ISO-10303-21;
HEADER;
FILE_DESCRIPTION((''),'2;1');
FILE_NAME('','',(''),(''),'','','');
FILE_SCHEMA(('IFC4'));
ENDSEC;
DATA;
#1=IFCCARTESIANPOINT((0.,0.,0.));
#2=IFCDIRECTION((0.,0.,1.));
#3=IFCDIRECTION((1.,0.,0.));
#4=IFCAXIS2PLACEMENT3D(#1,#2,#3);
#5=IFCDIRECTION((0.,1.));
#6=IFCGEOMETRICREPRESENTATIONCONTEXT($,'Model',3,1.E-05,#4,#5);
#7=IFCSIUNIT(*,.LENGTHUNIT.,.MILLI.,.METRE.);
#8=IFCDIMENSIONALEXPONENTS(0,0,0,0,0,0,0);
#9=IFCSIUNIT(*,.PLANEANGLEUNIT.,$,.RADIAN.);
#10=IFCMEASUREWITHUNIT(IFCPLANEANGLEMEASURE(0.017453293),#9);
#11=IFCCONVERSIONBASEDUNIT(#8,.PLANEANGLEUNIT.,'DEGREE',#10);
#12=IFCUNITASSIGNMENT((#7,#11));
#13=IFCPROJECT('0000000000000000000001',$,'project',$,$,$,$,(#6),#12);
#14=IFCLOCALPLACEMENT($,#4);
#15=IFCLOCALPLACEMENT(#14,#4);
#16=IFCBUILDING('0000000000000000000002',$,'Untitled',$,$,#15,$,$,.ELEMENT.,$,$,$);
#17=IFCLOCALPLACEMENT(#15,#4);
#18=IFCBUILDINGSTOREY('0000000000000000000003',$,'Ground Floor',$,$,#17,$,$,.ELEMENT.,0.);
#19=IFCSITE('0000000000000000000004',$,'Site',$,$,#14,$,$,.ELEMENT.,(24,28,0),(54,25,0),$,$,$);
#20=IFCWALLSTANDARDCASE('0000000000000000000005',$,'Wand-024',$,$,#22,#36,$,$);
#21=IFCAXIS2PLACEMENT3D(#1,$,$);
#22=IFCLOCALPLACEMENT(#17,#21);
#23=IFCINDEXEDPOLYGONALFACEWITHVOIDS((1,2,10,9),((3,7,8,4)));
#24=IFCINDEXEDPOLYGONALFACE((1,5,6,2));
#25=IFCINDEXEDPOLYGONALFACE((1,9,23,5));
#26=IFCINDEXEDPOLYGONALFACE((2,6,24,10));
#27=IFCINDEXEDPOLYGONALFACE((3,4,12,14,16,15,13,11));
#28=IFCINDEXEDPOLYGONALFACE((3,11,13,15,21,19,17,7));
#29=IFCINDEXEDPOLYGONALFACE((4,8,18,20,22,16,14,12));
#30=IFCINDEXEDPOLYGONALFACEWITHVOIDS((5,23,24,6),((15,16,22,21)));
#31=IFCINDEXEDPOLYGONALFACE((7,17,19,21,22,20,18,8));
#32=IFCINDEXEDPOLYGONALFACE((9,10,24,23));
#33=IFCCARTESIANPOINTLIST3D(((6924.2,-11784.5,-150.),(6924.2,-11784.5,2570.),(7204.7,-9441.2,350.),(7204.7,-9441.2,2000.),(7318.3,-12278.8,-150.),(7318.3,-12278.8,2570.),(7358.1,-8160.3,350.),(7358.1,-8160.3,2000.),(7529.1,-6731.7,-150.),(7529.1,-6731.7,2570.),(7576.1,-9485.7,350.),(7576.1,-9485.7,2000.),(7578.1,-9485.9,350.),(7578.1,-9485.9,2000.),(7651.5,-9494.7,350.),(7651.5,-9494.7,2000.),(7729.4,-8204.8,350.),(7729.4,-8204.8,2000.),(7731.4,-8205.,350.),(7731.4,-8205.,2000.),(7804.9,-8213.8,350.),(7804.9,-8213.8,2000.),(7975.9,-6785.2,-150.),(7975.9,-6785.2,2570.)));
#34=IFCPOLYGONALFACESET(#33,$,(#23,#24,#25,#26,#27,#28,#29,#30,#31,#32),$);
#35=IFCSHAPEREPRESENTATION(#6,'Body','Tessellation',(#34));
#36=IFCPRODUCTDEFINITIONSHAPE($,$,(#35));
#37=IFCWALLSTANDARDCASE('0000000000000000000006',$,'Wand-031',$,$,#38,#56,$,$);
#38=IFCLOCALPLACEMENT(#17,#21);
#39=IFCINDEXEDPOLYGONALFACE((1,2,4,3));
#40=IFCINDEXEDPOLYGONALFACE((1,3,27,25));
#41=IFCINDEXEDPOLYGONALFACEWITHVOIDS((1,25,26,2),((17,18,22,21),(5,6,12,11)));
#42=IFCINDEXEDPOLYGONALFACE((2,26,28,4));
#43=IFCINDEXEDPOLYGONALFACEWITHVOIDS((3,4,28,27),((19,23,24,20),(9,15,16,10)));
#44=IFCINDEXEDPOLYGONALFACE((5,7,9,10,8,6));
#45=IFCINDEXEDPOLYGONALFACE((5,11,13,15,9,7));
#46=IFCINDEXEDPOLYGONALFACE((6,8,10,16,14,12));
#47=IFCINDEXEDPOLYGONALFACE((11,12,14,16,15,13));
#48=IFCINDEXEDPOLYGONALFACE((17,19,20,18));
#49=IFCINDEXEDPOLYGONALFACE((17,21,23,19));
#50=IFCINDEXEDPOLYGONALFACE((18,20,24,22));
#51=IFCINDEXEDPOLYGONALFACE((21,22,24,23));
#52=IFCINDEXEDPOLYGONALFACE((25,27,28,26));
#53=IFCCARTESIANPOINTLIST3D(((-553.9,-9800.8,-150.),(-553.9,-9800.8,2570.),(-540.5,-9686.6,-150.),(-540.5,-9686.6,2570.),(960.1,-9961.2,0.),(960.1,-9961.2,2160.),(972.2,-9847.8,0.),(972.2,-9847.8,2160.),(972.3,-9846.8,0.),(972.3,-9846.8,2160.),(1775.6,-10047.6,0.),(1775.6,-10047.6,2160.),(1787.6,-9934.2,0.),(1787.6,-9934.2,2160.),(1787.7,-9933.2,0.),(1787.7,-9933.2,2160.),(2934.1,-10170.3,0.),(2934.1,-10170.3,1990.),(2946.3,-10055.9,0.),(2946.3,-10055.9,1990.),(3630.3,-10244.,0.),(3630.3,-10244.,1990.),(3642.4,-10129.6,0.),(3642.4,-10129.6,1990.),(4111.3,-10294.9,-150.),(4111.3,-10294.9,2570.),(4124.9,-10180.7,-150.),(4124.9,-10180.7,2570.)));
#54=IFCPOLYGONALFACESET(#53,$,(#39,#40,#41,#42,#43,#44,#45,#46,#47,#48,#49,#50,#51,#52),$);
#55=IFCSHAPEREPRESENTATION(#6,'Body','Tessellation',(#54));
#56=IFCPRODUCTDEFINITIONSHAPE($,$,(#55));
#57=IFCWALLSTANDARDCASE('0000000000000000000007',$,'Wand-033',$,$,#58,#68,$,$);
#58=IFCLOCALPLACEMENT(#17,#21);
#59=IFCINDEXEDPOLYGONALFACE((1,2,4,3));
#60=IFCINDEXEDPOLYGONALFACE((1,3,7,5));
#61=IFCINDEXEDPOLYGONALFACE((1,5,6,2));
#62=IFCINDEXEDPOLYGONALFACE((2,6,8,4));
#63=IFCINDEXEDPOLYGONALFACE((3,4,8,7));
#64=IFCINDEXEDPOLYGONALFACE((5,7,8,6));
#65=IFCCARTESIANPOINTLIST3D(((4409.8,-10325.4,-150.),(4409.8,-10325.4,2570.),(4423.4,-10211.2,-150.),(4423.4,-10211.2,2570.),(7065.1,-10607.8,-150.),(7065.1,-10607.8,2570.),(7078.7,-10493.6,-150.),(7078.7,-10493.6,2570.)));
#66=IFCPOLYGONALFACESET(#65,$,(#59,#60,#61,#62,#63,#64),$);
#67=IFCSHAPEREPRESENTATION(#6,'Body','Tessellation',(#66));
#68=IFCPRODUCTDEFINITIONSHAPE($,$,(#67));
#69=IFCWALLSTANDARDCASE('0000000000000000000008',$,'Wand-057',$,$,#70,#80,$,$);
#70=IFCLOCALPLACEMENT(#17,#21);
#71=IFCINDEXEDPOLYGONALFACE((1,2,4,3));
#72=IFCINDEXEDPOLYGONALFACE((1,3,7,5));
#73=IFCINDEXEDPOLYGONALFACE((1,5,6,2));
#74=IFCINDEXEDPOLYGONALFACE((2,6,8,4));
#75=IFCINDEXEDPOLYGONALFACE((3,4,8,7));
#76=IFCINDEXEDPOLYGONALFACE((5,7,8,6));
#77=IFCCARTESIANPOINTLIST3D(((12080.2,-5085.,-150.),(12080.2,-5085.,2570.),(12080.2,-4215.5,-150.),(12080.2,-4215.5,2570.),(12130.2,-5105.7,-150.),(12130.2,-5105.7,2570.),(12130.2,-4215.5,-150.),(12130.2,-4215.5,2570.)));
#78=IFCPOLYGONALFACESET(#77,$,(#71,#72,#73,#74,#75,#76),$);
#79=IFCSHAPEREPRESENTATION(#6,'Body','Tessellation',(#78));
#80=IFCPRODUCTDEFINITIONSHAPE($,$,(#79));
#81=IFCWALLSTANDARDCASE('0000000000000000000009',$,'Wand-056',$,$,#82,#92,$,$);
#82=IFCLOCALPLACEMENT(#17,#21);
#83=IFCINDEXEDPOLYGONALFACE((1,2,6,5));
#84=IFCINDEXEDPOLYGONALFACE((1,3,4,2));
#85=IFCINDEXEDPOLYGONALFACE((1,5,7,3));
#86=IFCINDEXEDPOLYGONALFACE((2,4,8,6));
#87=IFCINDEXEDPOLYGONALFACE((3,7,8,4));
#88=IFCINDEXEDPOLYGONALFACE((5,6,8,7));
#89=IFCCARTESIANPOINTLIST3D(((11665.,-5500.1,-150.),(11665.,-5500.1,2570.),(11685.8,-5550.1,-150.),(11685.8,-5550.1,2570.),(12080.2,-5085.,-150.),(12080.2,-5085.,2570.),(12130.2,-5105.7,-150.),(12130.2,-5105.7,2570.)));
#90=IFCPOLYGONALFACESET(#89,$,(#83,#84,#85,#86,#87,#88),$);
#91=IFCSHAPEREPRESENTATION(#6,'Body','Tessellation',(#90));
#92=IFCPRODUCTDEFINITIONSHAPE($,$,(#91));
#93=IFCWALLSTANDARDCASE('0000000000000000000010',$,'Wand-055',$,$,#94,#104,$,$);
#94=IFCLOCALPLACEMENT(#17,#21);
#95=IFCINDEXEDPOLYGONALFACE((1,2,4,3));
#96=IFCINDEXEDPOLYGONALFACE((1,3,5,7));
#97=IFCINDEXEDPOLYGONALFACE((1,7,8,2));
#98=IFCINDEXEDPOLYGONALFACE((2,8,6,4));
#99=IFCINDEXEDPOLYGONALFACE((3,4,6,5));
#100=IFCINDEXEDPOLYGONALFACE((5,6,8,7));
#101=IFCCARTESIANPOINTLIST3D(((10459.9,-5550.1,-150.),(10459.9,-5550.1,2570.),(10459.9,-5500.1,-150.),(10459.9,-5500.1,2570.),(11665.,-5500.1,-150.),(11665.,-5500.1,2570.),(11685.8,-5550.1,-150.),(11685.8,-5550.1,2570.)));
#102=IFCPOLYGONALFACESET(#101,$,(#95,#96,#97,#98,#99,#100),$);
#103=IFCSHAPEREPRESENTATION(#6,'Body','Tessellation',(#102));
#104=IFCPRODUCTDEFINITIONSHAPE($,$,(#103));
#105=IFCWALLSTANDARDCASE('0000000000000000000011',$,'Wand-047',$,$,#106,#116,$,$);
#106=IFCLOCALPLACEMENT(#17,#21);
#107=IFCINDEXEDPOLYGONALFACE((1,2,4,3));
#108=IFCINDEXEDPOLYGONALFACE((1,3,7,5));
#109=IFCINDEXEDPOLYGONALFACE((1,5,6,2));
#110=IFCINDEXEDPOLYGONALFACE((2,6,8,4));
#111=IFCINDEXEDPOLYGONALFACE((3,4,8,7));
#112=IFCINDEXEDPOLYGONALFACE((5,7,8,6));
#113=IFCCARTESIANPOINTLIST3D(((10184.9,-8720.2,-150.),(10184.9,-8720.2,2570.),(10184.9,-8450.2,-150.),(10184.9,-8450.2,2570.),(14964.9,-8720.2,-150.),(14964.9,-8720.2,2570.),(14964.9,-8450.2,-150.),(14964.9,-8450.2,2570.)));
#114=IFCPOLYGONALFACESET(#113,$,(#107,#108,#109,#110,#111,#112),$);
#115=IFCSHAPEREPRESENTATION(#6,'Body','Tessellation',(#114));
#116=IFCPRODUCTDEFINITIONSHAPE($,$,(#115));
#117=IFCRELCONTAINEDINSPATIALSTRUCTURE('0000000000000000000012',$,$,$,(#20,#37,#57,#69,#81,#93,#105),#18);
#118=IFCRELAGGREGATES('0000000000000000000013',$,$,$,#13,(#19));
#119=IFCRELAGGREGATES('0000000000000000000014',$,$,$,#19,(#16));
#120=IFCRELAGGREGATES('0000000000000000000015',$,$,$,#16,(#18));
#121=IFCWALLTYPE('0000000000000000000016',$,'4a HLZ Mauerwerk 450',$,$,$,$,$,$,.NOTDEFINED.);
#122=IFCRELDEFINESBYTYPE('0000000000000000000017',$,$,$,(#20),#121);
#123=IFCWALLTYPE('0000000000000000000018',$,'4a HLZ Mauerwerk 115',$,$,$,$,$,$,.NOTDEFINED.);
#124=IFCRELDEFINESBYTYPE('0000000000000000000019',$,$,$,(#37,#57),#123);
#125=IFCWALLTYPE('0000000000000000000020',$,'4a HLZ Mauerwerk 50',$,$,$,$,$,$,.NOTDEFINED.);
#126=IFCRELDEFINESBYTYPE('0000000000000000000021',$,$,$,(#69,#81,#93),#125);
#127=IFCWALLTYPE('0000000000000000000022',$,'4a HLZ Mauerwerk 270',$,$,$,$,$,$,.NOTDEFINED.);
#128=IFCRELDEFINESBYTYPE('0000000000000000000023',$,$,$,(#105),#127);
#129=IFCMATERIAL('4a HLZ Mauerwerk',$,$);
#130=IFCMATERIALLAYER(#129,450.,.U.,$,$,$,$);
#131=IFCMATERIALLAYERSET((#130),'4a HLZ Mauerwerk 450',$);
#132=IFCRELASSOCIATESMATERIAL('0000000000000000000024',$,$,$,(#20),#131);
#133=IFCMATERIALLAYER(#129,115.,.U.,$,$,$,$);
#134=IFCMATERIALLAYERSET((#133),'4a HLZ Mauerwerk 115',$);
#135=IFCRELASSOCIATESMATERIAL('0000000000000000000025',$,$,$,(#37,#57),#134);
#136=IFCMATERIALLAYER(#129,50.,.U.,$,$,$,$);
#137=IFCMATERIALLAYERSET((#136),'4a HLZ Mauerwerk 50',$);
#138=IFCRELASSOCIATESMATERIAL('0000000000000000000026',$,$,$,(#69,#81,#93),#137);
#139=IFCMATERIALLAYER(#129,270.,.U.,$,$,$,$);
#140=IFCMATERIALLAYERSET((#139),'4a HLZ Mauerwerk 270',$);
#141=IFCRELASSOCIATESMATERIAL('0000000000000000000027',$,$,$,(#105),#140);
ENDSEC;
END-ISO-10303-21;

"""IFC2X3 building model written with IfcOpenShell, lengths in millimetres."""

from ifc_helpers import new_model, entity, si_unit, converted_unit, direction, frame, origin_with_axes, origin_2d_with_axis, place, context, project, spatial, polyline, rectangle, outline, extrude, material, layer, layer_set, layer_usage, type_object, element, save


model = new_model("IFC2X3")

# Units and contexts
model_context = context("Model", 3, precision=1e-05, world=origin_with_axes(), true_north=direction((0.0, 1.0)))
ifc_project = project(units=[si_unit("LENGTHUNIT", "METRE", prefix="MILLI"), converted_unit("PLANEANGLEUNIT", "DEGREE", entity("IfcPlaneAngleMeasure", 0.017453293), si_unit("PLANEANGLEUNIT", "RADIAN"), dimensions=[0, 0, 0, 0, 0, 0, 0])], contexts=[model_context])

# Site, building, storey
site_placement = place(None, origin_with_axes())
site = spatial("IfcSite", under=ifc_project, at=site_placement, Name="Site", CompositionType="ELEMENT", RefLatitude=(24, 28, 0), RefLongitude=(54, 25, 0))
building_placement = place(site_placement, origin_with_axes())
building = spatial("IfcBuilding", under=site, at=building_placement, Name="Untitled", CompositionType="ELEMENT")
storey_placement = place(building_placement, origin_with_axes())
storey = spatial("IfcBuildingStorey", under=building, at=storey_placement, Name="Ground Floor", CompositionType="ELEMENT", Elevation=0.0)

# Shared definitions
ifc_material_1 = material(Name="4a HLZ Mauerwerk")

# Shared definitions
ifc_layer_1 = layer(ifc_material_1, 450.0, ventilated="UNKNOWN")
ifc_layer_set_1 = layer_set([ifc_layer_1], Name="4a HLZ Mauerwerk 450")
wall_type_1 = type_object("IfcWallType", Name="4a HLZ Mauerwerk 450", PredefinedType="NOTDEFINED")

# Wall, opening
ifc_layer_usage_1 = layer_usage(ifc_layer_set_1, "AXIS2", "NEGATIVE", 0.0)
wall_1_placement = place(storey_placement, frame((6924.2, -11784.5, -150.0), z_axis=(0.0, 0.0, 1.0), x_axis=(0.118857, 0.992911, 0.0)))
wall_1 = element("IfcWallStandardCase", 1, at=wall_1_placement, inside=storey, type_object=wall_type_1, material=ifc_layer_usage_1, Name="Wand-024", context=model_context, shape_type="SweptSolid", body=[
    extrude(outline(polyline([(-443.9, -450.0), (5088.9, -450.0), (5088.9, 0.0), (0.0, 0.0), (-443.9, -450.0)])), origin_with_axes(), (0.0, 0.0, 1.0), 2720.0),
])
opening_1_placement = place(wall_1_placement, frame((3005.1, 0.0, 500.0), z_axis=(0.0, 0.0, 1.0), x_axis=(1.0, 0.0, 0.0)))
element("IfcOpeningElement", 2, at=opening_1_placement, cuts=wall_1, context=model_context, shape_type="SweptSolid", body=[
    extrude(rectangle(XDim=1290.0, YDim=1650.0, at=origin_2d_with_axis()), frame((0.0, -1276.0, 825.0), z_axis=(0.0, 1.0, 0.0), x_axis=(1.0, 0.0, 0.0)), (0.0, 0.0, 1.0), 902.0),
    extrude(rectangle(XDim=1290.0, YDim=1650.0, at=origin_2d_with_axis()), frame((0.0, 526.0, 825.0), z_axis=(0.0, -1.0, 0.0), x_axis=(1.0, 0.0, 0.0)), (0.0, 0.0, 1.0), 902.0),
])

# Wall, openings
ifc_layer_2 = layer(ifc_material_1, 115.0, ventilated="UNKNOWN")
ifc_layer_set_2 = layer_set([ifc_layer_2], Name="4a HLZ Mauerwerk 115")
ifc_layer_usage_2 = layer_usage(ifc_layer_set_2, "AXIS2", "NEGATIVE", 0.0)
wall_type_2 = type_object("IfcWallType", Name="4a HLZ Mauerwerk 115", PredefinedType="NOTDEFINED")
wall_2_placement = place(storey_placement, frame((-540.5, -9686.6, -150.0), z_axis=(0.0, 0.0, 1.0), x_axis=(0.994438, -0.105328, 0.0)))
wall_2 = element("IfcWallStandardCase", 3, at=wall_2_placement, inside=storey, type_object=wall_type_2, material=ifc_layer_usage_2, Name="Wand-031", context=model_context, shape_type="SweptSolid", body=[
    extrude(outline(polyline([(-1.3, -115.0), (4690.0, -115.0), (4691.6, 0.0), (0.0, 0.0), (-1.3, -115.0)])), origin_with_axes(), (0.0, 0.0, 1.0), 2720.0),
])
opening_2_placement = place(wall_2_placement, frame((3856.3, 0.0, 150.0), z_axis=(0.0, 0.0, 1.0), x_axis=(1.0, 0.0, 0.0)))
element("IfcOpeningElement", 4, at=opening_2_placement, cuts=wall_2, context=model_context, shape_type="SweptSolid", body=[
    extrude(rectangle(XDim=700.0, YDim=1990.0, at=origin_2d_with_axis()), frame((0.0, -1460.0, 995.0), z_axis=(0.0, 1.0, 0.0), x_axis=(1.0, 0.0, 0.0)), (0.0, 0.0, 1.0), 2690.0),
])
opening_3_placement = place(wall_2_placement, frame((1931.2, 0.0, 150.0), z_axis=(0.0, 0.0, 1.0), x_axis=(1.0, 0.0, 0.0)))
element("IfcOpeningElement", 5, at=opening_3_placement, cuts=wall_2, context=model_context, shape_type="SweptSolid", body=[
    extrude(rectangle(XDim=820.0, YDim=2160.0, at=origin_2d_with_axis()), frame((0.0, 231.0, 1080.0), z_axis=(0.0, -1.0, 0.0), x_axis=(1.0, 0.0, 0.0)), (0.0, 0.0, 1.0), 232.0),
    extrude(rectangle(XDim=820.0, YDim=2160.0, at=origin_2d_with_axis()), frame((0.0, -231.0, 1080.0), z_axis=(0.0, 1.0, 0.0), x_axis=(1.0, 0.0, 0.0)), (0.0, 0.0, 1.0), 232.0),
])

# Walls
ifc_layer_usage_3 = layer_usage(ifc_layer_set_2, "AXIS2", "POSITIVE", 0.0)
wall_3_placement = place(storey_placement, frame((7078.7, -10493.6, -150.0), z_axis=(0.0, 0.0, 1.0), x_axis=(-0.994391, 0.105767, 0.0)))
element("IfcWallStandardCase", 6, at=wall_3_placement, inside=storey, type_object=wall_type_2, material=ifc_layer_usage_3, Name="Wand-033", context=model_context, shape_type="SweptSolid", body=[
    extrude(outline(polyline([(0.0, 0.0), (2670.3, 0.0), (2671.8, 115.0), (1.5, 115.0), (0.0, 0.0)])), origin_with_axes(), (0.0, 0.0, 1.0), 2720.0),
])
ifc_layer_3 = layer(ifc_material_1, 50.0, ventilated="UNKNOWN")
ifc_layer_set_3 = layer_set([ifc_layer_3], Name="4a HLZ Mauerwerk 50")
wall_type_3 = type_object("IfcWallType", Name="4a HLZ Mauerwerk 50", PredefinedType="NOTDEFINED")
ifc_layer_usage_4 = layer_usage(ifc_layer_set_3, "AXIS2", "POSITIVE", 0.0)
wall_4_placement = place(storey_placement, frame((12130.2, -5105.7, -150.0), z_axis=(0.0, 0.0, 1.0), x_axis=(0.0, 1.0, 0.0)))
element("IfcWallStandardCase", 7, at=wall_4_placement, inside=storey, type_object=wall_type_3, material=ifc_layer_usage_4, Name="Wand-057", context=model_context, shape_type="SweptSolid", body=[
    extrude(outline(polyline([(0.0, 0.0), (890.1, 0.0), (890.1, 50.0), (20.7, 50.0), (0.0, 0.0)])), origin_with_axes(), (0.0, 0.0, 1.0), 2720.0),
])
ifc_layer_usage_5 = layer_usage(ifc_layer_set_3, "AXIS2", "POSITIVE", 0.0)
wall_5_placement = place(storey_placement, frame((11685.8, -5550.1, -150.0), z_axis=(0.0, 0.0, 1.0), x_axis=(0.707107, 0.707107, 0.0)))
element("IfcWallStandardCase", 8, at=wall_5_placement, inside=storey, type_object=wall_type_3, material=ifc_layer_usage_5, Name="Wand-056", context=model_context, shape_type="SweptSolid", body=[
    extrude(outline(polyline([(0.0, 0.0), (628.5, 0.0), (607.8, 50.0), (20.7, 50.0), (0.0, 0.0)])), origin_with_axes(), (0.0, 0.0, 1.0), 2720.0),
])
ifc_layer_usage_6 = layer_usage(ifc_layer_set_3, "AXIS2", "POSITIVE", 0.0)
wall_6_placement = place(storey_placement, frame((10459.9, -5550.1, -150.0), z_axis=(0.0, 0.0, 1.0), x_axis=(1.0, 0.0, 0.0)))
element("IfcWallStandardCase", 9, at=wall_6_placement, inside=storey, type_object=wall_type_3, material=ifc_layer_usage_6, Name="Wand-055", context=model_context, shape_type="SweptSolid", body=[
    extrude(outline(polyline([(0.0, 0.0), (1225.9, 0.0), (1205.2, 50.0), (0.0, 50.0), (0.0, 0.0)])), origin_with_axes(), (0.0, 0.0, 1.0), 2720.0),
])
ifc_layer_4 = layer(ifc_material_1, 270.0, ventilated="UNKNOWN")
ifc_layer_set_4 = layer_set([ifc_layer_4], Name="4a HLZ Mauerwerk 270")
ifc_layer_usage_7 = layer_usage(ifc_layer_set_4, "AXIS2", "NEGATIVE", 0.0)
wall_type_4 = type_object("IfcWallType", Name="4a HLZ Mauerwerk 270", PredefinedType="NOTDEFINED")
wall_7_placement = place(storey_placement, frame((10184.9, -8450.2, -150.0), z_axis=(0.0, 0.0, 1.0), x_axis=(1.0, 0.0, 0.0)))
element("IfcWallStandardCase", 10, at=wall_7_placement, inside=storey, type_object=wall_type_4, material=ifc_layer_usage_7, Name="Wand-047", context=model_context, shape_type="SweptSolid", body=[
    extrude(outline(polyline([(0.0, -270.0), (4780.0, -270.0), (4780.0, 0.0), (0.0, 0.0), (0.0, -270.0)])), origin_with_axes(), (0.0, 0.0, 1.0), 2720.0),
])

save(model, "model.ifc")
